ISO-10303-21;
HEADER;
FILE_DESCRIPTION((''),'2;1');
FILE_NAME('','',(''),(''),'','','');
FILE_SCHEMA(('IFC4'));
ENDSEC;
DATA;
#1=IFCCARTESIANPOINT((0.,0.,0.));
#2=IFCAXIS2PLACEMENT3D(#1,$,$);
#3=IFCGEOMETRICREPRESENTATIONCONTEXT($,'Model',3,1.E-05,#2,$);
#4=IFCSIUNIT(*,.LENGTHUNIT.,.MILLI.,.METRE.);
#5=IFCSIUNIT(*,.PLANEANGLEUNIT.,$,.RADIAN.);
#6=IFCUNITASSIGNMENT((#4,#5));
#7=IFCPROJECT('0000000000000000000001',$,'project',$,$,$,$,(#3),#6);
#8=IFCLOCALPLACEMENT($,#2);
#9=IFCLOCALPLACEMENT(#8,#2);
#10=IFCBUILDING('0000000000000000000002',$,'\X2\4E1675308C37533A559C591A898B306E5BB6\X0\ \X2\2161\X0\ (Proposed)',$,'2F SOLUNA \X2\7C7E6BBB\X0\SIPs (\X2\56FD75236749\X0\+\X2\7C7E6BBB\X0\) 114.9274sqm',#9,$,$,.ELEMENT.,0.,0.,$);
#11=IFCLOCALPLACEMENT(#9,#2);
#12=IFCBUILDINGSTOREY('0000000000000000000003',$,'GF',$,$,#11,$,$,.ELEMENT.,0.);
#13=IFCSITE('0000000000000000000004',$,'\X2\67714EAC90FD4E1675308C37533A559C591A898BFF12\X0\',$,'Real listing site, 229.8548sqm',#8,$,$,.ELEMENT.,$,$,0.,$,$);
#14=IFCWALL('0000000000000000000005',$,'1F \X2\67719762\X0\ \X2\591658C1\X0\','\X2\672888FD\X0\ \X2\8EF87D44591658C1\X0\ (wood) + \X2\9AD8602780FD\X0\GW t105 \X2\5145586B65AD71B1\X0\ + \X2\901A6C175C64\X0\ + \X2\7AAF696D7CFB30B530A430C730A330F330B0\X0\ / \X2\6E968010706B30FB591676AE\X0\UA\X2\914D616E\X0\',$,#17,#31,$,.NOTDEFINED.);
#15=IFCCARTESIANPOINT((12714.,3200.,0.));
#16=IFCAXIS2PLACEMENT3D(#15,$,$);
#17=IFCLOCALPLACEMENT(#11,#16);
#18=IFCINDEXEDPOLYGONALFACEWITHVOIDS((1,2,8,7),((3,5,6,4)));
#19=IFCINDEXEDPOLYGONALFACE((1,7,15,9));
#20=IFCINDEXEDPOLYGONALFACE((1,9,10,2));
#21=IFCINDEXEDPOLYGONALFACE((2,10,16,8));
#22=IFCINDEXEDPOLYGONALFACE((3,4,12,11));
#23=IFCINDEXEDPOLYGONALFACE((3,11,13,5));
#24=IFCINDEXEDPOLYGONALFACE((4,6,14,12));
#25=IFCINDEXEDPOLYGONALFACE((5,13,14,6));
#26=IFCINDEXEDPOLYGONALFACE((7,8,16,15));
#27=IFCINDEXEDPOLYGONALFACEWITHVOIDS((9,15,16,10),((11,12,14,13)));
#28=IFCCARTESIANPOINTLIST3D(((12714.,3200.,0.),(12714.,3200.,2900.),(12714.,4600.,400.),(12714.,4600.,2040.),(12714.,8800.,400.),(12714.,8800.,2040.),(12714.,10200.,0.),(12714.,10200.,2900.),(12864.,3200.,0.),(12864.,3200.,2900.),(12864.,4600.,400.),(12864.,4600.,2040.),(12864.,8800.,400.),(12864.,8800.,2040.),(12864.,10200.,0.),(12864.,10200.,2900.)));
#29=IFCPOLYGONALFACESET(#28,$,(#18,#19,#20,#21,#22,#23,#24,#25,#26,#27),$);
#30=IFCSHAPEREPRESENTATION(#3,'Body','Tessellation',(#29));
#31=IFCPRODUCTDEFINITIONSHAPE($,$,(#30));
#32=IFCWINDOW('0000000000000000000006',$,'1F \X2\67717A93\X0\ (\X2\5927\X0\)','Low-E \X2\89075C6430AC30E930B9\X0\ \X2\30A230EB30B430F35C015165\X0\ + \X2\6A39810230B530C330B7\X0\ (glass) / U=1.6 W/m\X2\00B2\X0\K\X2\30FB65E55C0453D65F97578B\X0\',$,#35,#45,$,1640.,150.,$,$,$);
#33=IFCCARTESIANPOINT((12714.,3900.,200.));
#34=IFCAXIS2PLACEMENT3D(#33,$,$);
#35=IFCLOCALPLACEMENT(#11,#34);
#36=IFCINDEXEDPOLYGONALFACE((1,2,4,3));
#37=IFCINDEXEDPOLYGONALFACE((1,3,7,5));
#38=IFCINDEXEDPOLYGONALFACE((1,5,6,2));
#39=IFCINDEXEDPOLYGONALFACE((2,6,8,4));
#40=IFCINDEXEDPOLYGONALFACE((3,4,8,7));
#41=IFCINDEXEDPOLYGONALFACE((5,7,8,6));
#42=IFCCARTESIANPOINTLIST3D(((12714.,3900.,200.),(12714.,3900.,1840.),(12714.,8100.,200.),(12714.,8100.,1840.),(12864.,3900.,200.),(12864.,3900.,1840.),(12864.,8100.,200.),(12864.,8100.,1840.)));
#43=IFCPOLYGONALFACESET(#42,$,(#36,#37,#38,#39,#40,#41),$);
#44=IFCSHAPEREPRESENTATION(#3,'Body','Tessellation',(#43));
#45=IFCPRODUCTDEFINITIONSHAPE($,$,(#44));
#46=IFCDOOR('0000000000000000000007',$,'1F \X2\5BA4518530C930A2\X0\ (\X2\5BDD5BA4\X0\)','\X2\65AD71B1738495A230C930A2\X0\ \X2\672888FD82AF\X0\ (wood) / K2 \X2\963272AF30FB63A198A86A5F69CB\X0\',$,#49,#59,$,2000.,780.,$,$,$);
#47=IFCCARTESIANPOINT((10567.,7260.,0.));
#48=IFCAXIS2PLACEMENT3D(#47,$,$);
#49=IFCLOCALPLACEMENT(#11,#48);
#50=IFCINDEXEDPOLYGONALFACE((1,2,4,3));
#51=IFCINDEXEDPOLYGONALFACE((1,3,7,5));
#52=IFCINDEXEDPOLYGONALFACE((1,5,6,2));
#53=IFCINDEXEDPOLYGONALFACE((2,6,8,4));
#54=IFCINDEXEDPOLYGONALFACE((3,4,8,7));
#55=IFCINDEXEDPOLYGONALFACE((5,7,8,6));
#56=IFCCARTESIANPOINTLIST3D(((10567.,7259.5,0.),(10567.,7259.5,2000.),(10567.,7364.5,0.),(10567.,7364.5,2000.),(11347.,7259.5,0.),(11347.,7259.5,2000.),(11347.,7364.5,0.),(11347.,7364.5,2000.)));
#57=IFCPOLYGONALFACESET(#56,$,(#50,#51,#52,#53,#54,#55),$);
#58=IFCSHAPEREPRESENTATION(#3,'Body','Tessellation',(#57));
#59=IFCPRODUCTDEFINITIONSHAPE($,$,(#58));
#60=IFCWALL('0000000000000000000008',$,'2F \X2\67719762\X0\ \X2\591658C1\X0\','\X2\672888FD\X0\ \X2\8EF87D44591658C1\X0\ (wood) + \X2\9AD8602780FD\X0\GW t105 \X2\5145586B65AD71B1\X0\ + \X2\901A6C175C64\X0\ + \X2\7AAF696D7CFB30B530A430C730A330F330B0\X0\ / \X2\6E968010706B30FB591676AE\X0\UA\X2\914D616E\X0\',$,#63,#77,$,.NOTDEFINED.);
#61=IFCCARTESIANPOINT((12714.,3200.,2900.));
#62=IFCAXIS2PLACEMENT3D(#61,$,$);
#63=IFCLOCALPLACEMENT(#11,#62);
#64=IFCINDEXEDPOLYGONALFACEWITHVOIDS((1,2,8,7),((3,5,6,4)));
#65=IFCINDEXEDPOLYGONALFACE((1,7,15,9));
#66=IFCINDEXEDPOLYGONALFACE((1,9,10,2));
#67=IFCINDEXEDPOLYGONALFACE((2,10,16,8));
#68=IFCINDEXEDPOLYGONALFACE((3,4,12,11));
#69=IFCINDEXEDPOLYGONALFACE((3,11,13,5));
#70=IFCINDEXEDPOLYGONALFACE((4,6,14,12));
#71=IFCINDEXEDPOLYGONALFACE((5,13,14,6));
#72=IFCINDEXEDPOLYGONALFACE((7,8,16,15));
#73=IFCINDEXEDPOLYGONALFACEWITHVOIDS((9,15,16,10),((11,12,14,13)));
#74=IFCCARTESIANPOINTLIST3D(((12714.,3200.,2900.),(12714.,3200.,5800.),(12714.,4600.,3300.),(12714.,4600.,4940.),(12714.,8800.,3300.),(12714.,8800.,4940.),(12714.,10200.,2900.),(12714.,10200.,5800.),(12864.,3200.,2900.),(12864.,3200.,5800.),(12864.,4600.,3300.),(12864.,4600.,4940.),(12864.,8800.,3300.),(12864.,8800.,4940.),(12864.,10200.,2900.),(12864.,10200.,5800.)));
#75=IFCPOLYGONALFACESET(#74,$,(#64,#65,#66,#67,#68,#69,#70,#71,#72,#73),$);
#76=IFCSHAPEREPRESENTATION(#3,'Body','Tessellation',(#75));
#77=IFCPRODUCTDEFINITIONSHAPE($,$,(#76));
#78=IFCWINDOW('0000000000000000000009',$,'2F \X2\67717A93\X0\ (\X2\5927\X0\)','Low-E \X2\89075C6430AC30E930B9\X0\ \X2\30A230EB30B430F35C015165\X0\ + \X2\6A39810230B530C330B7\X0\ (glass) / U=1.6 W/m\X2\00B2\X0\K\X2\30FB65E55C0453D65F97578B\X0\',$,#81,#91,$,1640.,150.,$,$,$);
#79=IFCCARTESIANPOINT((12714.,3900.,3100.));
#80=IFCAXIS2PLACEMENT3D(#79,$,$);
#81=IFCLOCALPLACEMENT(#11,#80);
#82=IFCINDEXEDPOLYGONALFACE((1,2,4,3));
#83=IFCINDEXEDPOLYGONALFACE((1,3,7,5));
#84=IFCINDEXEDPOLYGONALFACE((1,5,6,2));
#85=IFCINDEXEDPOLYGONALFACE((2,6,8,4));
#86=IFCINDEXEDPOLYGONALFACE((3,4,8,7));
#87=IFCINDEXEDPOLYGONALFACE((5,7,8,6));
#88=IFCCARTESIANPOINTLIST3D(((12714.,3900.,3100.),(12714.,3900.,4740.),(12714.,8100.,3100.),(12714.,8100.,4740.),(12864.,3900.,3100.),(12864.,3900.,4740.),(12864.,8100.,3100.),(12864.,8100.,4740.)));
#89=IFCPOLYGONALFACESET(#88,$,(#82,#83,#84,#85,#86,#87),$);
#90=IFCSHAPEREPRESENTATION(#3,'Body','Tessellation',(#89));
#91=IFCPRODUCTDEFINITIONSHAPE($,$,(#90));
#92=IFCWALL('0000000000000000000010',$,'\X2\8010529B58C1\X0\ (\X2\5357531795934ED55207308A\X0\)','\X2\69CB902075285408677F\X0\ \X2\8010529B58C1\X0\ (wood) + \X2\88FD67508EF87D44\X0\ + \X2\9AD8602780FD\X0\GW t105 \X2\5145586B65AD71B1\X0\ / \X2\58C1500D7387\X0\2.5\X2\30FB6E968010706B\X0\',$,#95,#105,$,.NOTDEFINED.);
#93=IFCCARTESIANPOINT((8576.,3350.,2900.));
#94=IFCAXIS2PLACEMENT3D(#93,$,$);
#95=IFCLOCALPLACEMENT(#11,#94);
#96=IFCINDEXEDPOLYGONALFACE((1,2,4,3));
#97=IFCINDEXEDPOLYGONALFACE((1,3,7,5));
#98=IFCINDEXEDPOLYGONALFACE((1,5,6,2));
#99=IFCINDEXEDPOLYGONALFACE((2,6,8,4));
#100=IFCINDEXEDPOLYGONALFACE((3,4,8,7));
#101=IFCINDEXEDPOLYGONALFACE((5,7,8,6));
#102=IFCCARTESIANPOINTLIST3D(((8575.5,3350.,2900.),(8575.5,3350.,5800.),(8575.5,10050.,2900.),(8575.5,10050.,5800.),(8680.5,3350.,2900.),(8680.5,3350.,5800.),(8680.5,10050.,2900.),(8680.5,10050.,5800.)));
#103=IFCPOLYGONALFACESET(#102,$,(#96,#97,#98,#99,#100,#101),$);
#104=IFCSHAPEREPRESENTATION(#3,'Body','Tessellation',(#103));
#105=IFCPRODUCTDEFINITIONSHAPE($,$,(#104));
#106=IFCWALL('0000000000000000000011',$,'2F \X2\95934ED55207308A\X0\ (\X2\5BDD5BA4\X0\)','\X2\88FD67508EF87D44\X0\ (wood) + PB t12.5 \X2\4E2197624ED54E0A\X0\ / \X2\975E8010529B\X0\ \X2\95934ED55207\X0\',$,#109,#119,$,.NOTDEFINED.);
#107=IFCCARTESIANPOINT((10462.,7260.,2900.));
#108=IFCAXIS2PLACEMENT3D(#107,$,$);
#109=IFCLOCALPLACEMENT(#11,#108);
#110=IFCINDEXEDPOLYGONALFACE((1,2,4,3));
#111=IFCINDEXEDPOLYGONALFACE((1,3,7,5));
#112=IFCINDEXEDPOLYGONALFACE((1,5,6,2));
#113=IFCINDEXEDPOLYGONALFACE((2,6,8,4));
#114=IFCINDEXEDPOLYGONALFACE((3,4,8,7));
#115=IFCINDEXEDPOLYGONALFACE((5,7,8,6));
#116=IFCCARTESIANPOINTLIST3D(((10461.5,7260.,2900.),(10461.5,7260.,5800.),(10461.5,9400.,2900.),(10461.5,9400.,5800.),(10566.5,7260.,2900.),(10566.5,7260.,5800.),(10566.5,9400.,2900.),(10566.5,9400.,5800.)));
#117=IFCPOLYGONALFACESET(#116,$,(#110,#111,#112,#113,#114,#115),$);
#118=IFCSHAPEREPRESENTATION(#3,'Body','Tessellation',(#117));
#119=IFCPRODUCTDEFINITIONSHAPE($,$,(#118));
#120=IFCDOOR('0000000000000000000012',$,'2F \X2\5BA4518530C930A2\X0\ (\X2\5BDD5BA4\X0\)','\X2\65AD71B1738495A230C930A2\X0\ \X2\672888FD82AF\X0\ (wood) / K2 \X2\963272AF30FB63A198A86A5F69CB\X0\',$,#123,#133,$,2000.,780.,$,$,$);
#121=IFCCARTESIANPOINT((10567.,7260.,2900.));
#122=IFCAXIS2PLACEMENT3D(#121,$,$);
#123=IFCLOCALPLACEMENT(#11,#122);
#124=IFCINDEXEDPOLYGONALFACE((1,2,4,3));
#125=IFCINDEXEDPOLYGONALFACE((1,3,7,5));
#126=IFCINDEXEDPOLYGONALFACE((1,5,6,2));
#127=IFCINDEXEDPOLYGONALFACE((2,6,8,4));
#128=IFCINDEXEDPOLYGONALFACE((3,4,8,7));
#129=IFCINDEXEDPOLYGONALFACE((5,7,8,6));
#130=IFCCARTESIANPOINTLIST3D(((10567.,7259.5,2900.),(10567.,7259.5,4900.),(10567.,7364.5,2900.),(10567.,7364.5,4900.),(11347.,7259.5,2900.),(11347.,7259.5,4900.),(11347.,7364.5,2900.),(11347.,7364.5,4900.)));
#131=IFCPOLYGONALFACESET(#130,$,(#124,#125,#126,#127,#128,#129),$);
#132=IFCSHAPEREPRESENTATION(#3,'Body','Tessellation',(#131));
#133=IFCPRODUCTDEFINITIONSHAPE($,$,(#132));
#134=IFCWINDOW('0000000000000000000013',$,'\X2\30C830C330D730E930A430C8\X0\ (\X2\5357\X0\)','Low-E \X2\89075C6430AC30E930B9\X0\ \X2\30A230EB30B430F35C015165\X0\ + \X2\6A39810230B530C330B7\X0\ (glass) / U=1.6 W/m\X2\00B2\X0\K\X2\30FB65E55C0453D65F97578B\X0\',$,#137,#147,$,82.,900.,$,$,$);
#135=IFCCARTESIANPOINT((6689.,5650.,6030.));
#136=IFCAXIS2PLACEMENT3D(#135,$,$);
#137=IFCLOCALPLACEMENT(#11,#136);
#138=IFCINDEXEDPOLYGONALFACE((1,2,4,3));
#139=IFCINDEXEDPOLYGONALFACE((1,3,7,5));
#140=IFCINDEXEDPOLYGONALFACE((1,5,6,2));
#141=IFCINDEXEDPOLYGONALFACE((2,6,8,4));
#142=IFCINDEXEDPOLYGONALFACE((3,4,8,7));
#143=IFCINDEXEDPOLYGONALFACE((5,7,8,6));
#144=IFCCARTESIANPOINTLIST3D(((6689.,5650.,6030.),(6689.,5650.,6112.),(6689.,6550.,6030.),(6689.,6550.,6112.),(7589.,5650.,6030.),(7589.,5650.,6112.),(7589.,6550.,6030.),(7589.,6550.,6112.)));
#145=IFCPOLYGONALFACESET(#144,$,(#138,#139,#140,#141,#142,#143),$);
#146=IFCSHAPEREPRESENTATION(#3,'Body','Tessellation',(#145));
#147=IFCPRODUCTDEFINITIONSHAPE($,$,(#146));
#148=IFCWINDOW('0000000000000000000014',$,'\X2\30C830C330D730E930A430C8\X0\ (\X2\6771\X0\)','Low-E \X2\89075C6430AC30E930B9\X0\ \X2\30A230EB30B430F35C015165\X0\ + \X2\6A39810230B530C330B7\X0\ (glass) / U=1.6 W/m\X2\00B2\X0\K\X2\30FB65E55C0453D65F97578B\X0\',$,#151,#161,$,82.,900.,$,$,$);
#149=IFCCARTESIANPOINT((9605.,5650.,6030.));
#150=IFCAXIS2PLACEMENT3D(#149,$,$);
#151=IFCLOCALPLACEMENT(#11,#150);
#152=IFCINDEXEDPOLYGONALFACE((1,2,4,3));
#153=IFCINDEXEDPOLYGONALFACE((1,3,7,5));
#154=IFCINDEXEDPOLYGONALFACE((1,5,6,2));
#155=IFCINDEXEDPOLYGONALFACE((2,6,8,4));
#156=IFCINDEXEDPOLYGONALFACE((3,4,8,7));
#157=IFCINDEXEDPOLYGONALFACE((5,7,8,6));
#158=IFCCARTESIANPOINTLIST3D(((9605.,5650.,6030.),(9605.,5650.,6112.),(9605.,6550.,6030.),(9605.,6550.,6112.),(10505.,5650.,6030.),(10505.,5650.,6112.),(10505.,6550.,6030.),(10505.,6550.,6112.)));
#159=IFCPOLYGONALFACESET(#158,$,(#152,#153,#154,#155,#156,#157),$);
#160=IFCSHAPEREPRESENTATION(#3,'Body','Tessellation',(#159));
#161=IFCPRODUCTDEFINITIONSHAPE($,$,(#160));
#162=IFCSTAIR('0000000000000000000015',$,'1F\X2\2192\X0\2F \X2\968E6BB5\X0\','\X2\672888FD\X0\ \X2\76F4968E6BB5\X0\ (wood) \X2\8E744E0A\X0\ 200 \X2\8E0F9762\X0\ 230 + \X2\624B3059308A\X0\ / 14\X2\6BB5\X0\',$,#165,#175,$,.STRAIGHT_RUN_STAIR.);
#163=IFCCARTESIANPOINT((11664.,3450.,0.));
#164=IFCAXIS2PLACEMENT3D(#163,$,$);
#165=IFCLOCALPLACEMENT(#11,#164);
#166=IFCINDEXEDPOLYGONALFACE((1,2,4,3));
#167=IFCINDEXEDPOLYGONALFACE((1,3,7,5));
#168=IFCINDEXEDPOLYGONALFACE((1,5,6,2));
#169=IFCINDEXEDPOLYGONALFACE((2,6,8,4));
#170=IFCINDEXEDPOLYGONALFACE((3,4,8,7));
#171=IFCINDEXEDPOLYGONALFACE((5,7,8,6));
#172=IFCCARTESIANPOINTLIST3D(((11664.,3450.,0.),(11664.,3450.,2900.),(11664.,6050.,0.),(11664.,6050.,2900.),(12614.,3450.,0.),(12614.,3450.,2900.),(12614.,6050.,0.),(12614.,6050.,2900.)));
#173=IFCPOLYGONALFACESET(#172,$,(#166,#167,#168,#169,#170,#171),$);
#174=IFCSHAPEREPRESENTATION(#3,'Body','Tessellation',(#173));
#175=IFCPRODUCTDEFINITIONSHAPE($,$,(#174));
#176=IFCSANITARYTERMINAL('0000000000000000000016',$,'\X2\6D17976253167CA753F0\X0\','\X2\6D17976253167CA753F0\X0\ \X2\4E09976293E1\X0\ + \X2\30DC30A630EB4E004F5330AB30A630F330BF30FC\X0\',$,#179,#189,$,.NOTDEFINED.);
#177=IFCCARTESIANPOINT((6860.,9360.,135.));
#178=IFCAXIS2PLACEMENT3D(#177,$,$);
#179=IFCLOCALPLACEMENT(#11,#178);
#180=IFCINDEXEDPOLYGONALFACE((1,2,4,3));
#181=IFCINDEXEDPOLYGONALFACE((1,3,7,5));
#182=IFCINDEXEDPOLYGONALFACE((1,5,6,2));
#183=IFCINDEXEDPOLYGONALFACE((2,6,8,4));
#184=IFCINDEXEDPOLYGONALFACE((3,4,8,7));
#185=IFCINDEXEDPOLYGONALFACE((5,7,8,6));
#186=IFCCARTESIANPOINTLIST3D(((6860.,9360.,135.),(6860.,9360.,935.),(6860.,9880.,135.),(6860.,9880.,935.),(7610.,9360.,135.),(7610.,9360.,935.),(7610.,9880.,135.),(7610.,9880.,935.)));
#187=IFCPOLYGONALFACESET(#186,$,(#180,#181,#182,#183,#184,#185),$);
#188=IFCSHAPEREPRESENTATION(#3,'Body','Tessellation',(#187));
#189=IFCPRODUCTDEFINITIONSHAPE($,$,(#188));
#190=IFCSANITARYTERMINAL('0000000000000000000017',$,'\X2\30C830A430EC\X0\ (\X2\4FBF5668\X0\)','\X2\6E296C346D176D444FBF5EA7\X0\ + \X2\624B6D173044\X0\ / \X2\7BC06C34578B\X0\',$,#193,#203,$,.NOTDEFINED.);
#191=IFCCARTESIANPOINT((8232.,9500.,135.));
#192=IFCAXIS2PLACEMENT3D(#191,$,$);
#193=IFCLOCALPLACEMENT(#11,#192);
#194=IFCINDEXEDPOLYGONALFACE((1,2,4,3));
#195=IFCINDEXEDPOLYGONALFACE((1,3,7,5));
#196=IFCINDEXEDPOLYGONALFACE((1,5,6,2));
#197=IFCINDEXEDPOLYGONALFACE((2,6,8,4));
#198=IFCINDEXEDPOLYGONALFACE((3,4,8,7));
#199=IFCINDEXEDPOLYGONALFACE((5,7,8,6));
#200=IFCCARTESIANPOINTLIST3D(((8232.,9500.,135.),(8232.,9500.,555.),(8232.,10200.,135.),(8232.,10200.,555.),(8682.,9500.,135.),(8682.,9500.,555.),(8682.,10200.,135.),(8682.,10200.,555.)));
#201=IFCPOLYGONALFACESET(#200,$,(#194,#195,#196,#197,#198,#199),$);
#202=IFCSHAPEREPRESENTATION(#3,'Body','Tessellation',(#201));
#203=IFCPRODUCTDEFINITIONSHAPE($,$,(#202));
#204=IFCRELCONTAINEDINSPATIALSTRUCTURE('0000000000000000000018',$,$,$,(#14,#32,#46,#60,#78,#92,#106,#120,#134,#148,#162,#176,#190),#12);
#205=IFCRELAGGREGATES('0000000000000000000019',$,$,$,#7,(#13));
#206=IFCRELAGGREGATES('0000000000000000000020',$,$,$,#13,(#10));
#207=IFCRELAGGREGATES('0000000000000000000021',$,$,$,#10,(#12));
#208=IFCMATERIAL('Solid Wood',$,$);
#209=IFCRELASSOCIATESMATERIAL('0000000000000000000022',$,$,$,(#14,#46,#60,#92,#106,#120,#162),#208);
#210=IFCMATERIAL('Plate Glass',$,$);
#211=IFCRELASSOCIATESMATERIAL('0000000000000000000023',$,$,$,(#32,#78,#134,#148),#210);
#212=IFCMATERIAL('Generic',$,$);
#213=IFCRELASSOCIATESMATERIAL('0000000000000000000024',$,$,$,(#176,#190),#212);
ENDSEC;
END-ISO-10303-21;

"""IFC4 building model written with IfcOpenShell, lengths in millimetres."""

from ifc_helpers import new_model, si_unit, frame, frame_2d, origin, place, context, project, spatial, rectangle, extrude, material, element, fill, save


model = new_model("IFC4")

# Units and contexts
model_context = context("Model", 3, precision=1e-05, world=origin())
ifc_project = project(units=[si_unit("LENGTHUNIT", "METRE", prefix="MILLI"), si_unit("PLANEANGLEUNIT", "RADIAN")], contexts=[model_context])

# Site, building, storey
site_placement = place(None, origin())
site = spatial("IfcSite", under=ifc_project, at=site_placement, Name="東京都世田谷区喜多見２", ObjectType="Real listing site, 229.8548sqm", CompositionType="ELEMENT", RefElevation=0.0)
building_placement = place(site_placement, origin())
building = spatial("IfcBuilding", under=site, at=building_placement, Name="世田谷区喜多見の家 Ⅱ (Proposed)", ObjectType="2F SOLUNA 籾殻SIPs (国産杉+籾殻) 114.9274sqm", CompositionType="ELEMENT", ElevationOfRefHeight=0.0, ElevationOfTerrain=0.0)
storey_placement = place(building_placement, origin())
storey = spatial("IfcBuildingStorey", under=building, at=storey_placement, Name="GF", CompositionType="ELEMENT", Elevation=0.0)

# Wall, opening, window
ifc_material_1 = material(Name="Solid Wood")
wall_1_placement = place(storey_placement, frame((12714.0, 3200.0, 0.0)))
wall_1 = element("IfcWall", 1, at=wall_1_placement, inside=storey, material=ifc_material_1, Name="1F 東面 外壁", Description="木製 軸組外壁 (wood) + 高性能GW t105 充填断熱 + 通気層 + 窯業系サイディング / 準耐火・外皮UA配慮", PredefinedType="NOTDEFINED", context=model_context, shape_type="SweptSolid", body=[
    extrude(rectangle(XDim=150.0, YDim=7000.0, at=frame_2d((75.0, 3500.0))), frame((12714.0, 3200.0, 0.0)), (0.0, 0.0, 1.0), 2900.0),
])
opening_1_placement = place(storey_placement, frame((12714.0, 3900.0, 200.0)))
opening_1 = element("IfcOpeningElement", 2, at=opening_1_placement, cuts=wall_1, PredefinedType="NOTDEFINED", context=model_context, shape_type="SweptSolid", body=[
    extrude(rectangle(XDim=150.0, YDim=4200.0, at=frame_2d((75.0, 2100.0))), frame((12714.0, 3900.0, 200.0)), (0.0, 0.0, 1.0), 1640.0),
])
ifc_material_2 = material(Name="Plate Glass")
window_1_placement = place(storey_placement, frame((12714.0, 3900.0, 200.0)))
window_1 = element("IfcWindow", 3, at=window_1_placement, inside=storey, material=ifc_material_2, Name="1F 東窓 (大)", Description="Low-E 複層ガラス アルゴン封入 + 樹脂サッシ (glass) / U=1.6 W/m²K・日射取得型", OverallHeight=1640.0, OverallWidth=150.0, context=model_context, shape_type="SweptSolid", body=[
    extrude(rectangle(XDim=150.0, YDim=4200.0, at=frame_2d((75.0, 2100.0))), frame((12714.0, 3900.0, 200.0)), (0.0, 0.0, 1.0), 1640.0),
])
fill(opening_1, window_1)

# Door
door_1_placement = place(storey_placement, frame((10567.0, 7260.0, 0.0)))
element("IfcDoor", 4, at=door_1_placement, inside=storey, material=ifc_material_1, Name="1F 室内ドア (寝室)", Description="断熱玄関ドア 木製芯 (wood) / K2 防犯・採風機構", OverallHeight=2000.0, OverallWidth=780.0, context=model_context, shape_type="SweptSolid", body=[
    extrude(rectangle(XDim=780.0, YDim=105.0, at=frame_2d((390.0, 52.0))), frame((10567.0, 7260.0, 0.0)), (0.0, 0.0, 1.0), 2000.0),
])

# Wall, opening, window
wall_2_placement = place(storey_placement, frame((12714.0, 3200.0, 2900.0)))
wall_2 = element("IfcWall", 5, at=wall_2_placement, inside=storey, material=ifc_material_1, Name="2F 東面 外壁", Description="木製 軸組外壁 (wood) + 高性能GW t105 充填断熱 + 通気層 + 窯業系サイディング / 準耐火・外皮UA配慮", PredefinedType="NOTDEFINED", context=model_context, shape_type="SweptSolid", body=[
    extrude(rectangle(XDim=150.0, YDim=7000.0, at=frame_2d((75.0, 3500.0))), frame((12714.0, 3200.0, 2900.0)), (0.0, 0.0, 1.0), 2900.0),
])
opening_2_placement = place(storey_placement, frame((12714.0, 3900.0, 3100.0)))
opening_2 = element("IfcOpeningElement", 6, at=opening_2_placement, cuts=wall_2, PredefinedType="NOTDEFINED", context=model_context, shape_type="SweptSolid", body=[
    extrude(rectangle(XDim=150.0, YDim=4200.0, at=frame_2d((75.0, 2100.0))), frame((12714.0, 3900.0, 3100.0)), (0.0, 0.0, 1.0), 1640.0),
])
window_2_placement = place(storey_placement, frame((12714.0, 3900.0, 3100.0)))
window_2 = element("IfcWindow", 7, at=window_2_placement, inside=storey, material=ifc_material_2, Name="2F 東窓 (大)", Description="Low-E 複層ガラス アルゴン封入 + 樹脂サッシ (glass) / U=1.6 W/m²K・日射取得型", OverallHeight=1640.0, OverallWidth=150.0, context=model_context, shape_type="SweptSolid", body=[
    extrude(rectangle(XDim=150.0, YDim=4200.0, at=frame_2d((75.0, 2100.0))), frame((12714.0, 3900.0, 3100.0)), (0.0, 0.0, 1.0), 1640.0),
])
fill(opening_2, window_2)

# Walls
wall_3_placement = place(storey_placement, frame((8576.0, 3350.0, 2900.0)))
element("IfcWall", 8, at=wall_3_placement, inside=storey, material=ifc_material_1, Name="耐力壁 (南北間仕切り)", Description="構造用合板 耐力壁 (wood) + 製材軸組 + 高性能GW t105 充填断熱 / 壁倍率2.5・準耐火", PredefinedType="NOTDEFINED", context=model_context, shape_type="SweptSolid", body=[
    extrude(rectangle(XDim=105.0, YDim=6700.0, at=frame_2d((52.0, 3350.0))), frame((8576.0, 3350.0, 2900.0)), (0.0, 0.0, 1.0), 2900.0),
])
wall_4_placement = place(storey_placement, frame((10462.0, 7260.0, 2900.0)))
element("IfcWall", 9, at=wall_4_placement, inside=storey, material=ifc_material_1, Name="2F 間仕切り (寝室)", Description="製材軸組 (wood) + PB t12.5 両面仕上 / 非耐力 間仕切", PredefinedType="NOTDEFINED", context=model_context, shape_type="SweptSolid", body=[
    extrude(rectangle(XDim=105.0, YDim=2140.0, at=frame_2d((52.0, 1070.0))), frame((10462.0, 7260.0, 2900.0)), (0.0, 0.0, 1.0), 2900.0),
])

# Door
door_2_placement = place(storey_placement, frame((10567.0, 7260.0, 2900.0)))
element("IfcDoor", 10, at=door_2_placement, inside=storey, material=ifc_material_1, Name="2F 室内ドア (寝室)", Description="断熱玄関ドア 木製芯 (wood) / K2 防犯・採風機構", OverallHeight=2000.0, OverallWidth=780.0, context=model_context, shape_type="SweptSolid", body=[
    extrude(rectangle(XDim=780.0, YDim=105.0, at=frame_2d((390.0, 52.0))), frame((10567.0, 7260.0, 2900.0)), (0.0, 0.0, 1.0), 2000.0),
])

# Windows
window_3_placement = place(storey_placement, frame((6689.0, 5650.0, 6030.0)))
element("IfcWindow", 11, at=window_3_placement, inside=storey, material=ifc_material_2, Name="トップライト (南)", Description="Low-E 複層ガラス アルゴン封入 + 樹脂サッシ (glass) / U=1.6 W/m²K・日射取得型", OverallHeight=82.0, OverallWidth=900.0, context=model_context, shape_type="SweptSolid", body=[
    extrude(rectangle(XDim=900.0, YDim=900.0, at=frame_2d((450.0, 450.0))), frame((6689.0, 5650.0, 6030.0)), (0.0, 0.0, 1.0), 82.0),
])
window_4_placement = place(storey_placement, frame((9605.0, 5650.0, 6030.0)))
element("IfcWindow", 12, at=window_4_placement, inside=storey, material=ifc_material_2, Name="トップライト (東)", Description="Low-E 複層ガラス アルゴン封入 + 樹脂サッシ (glass) / U=1.6 W/m²K・日射取得型", OverallHeight=82.0, OverallWidth=900.0, context=model_context, shape_type="SweptSolid", body=[
    extrude(rectangle(XDim=900.0, YDim=900.0, at=frame_2d((450.0, 450.0))), frame((9605.0, 5650.0, 6030.0)), (0.0, 0.0, 1.0), 82.0),
])

# Stair
stair_placement = place(storey_placement, frame((11664.0, 3450.0, 0.0)))
element("IfcStair", 13, at=stair_placement, inside=storey, material=ifc_material_1, Name="1F→2F 階段", Description="木製 直階段 (wood) 蹴上 200 踏面 230 + 手すり / 14段", PredefinedType="STRAIGHT_RUN_STAIR", context=model_context, shape_type="SweptSolid", body=[
    extrude(rectangle(XDim=950.0, YDim=2600.0, at=frame_2d((475.0, 1300.0))), frame((11664.0, 3450.0, 0.0)), (0.0, 0.0, 1.0), 2900.0),
])

# Sanitary terminals
ifc_material_3 = material(Name="Generic")
sanitary_terminal_1_placement = place(storey_placement, frame((6860.0, 9360.0, 135.0)))
element("IfcSanitaryTerminal", 14, at=sanitary_terminal_1_placement, inside=storey, material=ifc_material_3, Name="洗面化粧台", Description="洗面化粧台 三面鏡 + ボウル一体カウンター", PredefinedType="NOTDEFINED", context=model_context, shape_type="SweptSolid", body=[
    extrude(rectangle(XDim=750.0, YDim=520.0, at=frame_2d((375.0, 260.0))), frame((6860.0, 9360.0, 135.0)), (0.0, 0.0, 1.0), 800.0),
])
sanitary_terminal_2_placement = place(storey_placement, frame((8232.0, 9500.0, 135.0)))
element("IfcSanitaryTerminal", 15, at=sanitary_terminal_2_placement, inside=storey, material=ifc_material_3, Name="トイレ (便器)", Description="温水洗浄便座 + 手洗い / 節水型", PredefinedType="NOTDEFINED", context=model_context, shape_type="SweptSolid", body=[
    extrude(rectangle(XDim=450.0, YDim=700.0, at=frame_2d((225.0, 350.0))), frame((8232.0, 9500.0, 135.0)), (0.0, 0.0, 1.0), 420.0),
])

save(model, "model.ifc")
